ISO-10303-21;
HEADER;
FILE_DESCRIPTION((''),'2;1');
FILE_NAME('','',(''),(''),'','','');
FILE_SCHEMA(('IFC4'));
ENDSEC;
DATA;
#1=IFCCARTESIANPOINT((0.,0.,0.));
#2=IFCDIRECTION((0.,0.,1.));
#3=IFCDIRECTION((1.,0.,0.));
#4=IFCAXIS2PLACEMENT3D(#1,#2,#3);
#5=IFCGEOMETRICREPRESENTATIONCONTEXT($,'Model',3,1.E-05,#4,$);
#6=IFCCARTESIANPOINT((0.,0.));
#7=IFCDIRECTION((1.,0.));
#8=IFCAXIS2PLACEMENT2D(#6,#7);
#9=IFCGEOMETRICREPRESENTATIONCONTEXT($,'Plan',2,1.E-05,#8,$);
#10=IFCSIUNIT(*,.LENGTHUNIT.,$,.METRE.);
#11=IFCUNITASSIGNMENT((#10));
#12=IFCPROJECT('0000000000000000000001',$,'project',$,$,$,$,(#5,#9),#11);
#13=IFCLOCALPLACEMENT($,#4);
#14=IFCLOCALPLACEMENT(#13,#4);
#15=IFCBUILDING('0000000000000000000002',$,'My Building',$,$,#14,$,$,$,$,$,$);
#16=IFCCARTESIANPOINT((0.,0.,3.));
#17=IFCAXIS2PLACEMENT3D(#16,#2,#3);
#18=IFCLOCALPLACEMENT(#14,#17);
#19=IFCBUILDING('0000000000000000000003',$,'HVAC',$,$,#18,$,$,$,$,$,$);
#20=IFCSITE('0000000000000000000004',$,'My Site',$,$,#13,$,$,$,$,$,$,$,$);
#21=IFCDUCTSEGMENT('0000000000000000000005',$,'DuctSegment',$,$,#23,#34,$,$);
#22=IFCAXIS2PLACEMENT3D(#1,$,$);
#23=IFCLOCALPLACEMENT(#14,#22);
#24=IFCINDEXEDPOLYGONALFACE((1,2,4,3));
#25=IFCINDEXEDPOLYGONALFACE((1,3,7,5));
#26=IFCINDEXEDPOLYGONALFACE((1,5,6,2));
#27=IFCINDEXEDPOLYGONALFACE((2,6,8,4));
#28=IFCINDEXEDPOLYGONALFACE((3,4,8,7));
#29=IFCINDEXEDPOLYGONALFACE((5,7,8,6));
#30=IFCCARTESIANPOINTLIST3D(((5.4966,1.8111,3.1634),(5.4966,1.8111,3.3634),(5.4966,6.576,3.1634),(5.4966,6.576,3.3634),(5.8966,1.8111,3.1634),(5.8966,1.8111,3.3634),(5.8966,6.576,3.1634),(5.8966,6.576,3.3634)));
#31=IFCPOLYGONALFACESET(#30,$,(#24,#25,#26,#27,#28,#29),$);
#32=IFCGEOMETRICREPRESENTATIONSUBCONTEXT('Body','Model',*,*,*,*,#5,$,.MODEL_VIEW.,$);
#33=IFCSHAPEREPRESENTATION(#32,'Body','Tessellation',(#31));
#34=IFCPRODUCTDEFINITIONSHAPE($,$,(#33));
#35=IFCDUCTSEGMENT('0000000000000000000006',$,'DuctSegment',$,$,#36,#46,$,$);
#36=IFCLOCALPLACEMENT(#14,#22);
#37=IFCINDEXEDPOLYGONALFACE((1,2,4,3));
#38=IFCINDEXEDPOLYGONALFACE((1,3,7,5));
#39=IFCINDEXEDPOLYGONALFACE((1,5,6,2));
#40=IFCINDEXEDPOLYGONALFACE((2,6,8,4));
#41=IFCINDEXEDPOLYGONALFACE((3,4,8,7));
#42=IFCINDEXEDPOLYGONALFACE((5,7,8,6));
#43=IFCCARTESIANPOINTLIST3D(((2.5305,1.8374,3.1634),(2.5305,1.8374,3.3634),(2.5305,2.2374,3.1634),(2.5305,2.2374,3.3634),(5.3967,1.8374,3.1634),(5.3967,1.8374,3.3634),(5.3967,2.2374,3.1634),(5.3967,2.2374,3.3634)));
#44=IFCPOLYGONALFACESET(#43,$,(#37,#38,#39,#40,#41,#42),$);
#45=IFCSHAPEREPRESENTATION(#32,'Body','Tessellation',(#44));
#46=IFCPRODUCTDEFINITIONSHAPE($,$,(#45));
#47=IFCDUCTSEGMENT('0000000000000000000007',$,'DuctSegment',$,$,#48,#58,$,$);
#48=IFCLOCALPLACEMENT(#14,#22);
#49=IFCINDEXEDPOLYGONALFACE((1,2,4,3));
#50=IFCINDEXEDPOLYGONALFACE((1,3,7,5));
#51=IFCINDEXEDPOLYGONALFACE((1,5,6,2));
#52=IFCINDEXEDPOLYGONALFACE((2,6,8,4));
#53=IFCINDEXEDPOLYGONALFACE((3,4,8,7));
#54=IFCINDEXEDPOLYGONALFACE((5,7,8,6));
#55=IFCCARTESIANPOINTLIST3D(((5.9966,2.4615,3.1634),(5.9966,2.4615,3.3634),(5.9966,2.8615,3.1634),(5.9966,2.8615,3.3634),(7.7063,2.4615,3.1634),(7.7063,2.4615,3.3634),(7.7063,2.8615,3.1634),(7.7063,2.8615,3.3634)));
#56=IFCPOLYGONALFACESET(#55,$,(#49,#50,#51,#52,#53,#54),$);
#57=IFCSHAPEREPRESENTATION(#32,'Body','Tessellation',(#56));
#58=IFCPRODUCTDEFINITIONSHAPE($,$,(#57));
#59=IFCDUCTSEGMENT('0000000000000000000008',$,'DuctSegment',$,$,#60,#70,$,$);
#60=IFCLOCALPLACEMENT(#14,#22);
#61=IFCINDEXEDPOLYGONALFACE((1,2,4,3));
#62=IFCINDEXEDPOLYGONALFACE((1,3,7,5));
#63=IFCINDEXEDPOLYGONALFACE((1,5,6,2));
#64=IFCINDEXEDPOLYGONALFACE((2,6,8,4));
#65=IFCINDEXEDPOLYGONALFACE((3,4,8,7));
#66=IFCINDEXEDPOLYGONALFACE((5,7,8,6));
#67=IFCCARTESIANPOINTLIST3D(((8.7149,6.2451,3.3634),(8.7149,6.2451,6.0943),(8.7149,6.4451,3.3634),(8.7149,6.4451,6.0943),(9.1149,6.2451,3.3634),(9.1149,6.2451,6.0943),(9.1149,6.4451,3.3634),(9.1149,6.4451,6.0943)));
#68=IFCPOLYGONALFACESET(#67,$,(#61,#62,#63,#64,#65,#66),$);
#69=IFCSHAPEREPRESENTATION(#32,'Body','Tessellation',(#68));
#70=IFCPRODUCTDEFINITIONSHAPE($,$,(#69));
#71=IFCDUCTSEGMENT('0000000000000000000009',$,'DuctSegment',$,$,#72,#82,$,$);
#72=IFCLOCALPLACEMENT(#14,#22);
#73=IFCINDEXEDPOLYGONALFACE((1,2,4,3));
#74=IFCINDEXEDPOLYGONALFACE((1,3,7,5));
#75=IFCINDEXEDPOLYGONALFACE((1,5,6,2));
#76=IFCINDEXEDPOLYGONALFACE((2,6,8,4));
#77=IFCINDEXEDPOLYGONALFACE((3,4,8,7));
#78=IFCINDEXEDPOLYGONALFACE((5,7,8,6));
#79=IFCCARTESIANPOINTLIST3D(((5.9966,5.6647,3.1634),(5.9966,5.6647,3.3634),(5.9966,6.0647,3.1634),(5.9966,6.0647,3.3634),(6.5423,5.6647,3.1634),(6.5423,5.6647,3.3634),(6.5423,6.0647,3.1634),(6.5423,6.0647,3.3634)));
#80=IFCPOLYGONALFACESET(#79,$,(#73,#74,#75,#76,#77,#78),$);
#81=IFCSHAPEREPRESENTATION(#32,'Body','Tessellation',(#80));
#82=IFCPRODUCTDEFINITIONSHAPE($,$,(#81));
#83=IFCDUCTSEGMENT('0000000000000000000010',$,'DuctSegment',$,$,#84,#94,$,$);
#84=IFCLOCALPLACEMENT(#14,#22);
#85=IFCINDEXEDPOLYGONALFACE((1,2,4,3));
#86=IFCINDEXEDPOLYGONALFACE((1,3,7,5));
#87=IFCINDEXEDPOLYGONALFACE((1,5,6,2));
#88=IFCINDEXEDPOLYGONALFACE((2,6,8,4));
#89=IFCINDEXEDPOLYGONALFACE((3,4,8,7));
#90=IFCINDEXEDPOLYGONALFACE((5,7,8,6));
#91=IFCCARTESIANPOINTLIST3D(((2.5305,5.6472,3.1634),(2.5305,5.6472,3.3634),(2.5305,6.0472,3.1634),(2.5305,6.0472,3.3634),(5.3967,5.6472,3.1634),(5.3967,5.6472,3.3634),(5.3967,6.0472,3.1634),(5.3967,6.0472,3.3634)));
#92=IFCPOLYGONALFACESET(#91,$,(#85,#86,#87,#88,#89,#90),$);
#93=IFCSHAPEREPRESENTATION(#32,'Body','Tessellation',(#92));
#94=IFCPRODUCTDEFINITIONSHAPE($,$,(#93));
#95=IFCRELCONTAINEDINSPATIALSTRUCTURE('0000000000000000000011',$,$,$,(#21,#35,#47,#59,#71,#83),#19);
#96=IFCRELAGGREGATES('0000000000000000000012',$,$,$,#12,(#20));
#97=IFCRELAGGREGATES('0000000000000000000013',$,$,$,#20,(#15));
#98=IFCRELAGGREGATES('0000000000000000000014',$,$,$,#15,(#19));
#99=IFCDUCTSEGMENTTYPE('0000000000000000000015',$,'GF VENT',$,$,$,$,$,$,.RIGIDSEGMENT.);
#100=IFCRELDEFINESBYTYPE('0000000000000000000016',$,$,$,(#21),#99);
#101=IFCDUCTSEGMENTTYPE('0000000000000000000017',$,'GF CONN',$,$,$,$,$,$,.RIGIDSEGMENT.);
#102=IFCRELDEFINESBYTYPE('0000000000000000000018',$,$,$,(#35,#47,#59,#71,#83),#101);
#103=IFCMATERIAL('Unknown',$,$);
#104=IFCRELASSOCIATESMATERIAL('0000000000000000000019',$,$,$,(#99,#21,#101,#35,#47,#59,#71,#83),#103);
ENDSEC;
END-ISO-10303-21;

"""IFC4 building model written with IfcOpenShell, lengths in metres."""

from ifc_helpers import new_model, si_unit, frame, origin_with_axes, origin_2d_with_axis, place, context, subcontext, project, spatial, rectangle, extrude, material, material_profile, profile_set, profile_usage, type_object, element, save


model = new_model("IFC4")

# Units and contexts
model_context = context("Model", 3, precision=1e-05, world=origin_with_axes())
plan_context = context("Plan", 2, precision=1e-05, world=origin_2d_with_axis())
body_context = subcontext(model_context, "Body", "Model", "MODEL_VIEW")
ifc_project = project(units=[si_unit("LENGTHUNIT", "METRE")], contexts=[model_context, plan_context])

# Site, buildings
site_placement = place(None, origin_with_axes())
site = spatial("IfcSite", under=ifc_project, at=site_placement, Name="My Site")
building_1_placement = place(site_placement, origin_with_axes())
building_1 = spatial("IfcBuilding", under=site, at=building_1_placement, Name="My Building")
building_2_placement = place(building_1_placement, frame((0.0, 0.0, 3.0), z_axis=(0.0, 0.0, 1.0), x_axis=(1.0, 0.0, 0.0)))
building_2 = spatial("IfcBuilding", under=building_1, at=building_2_placement, Name="HVAC")

# Duct segments
ifc_material = material(Name="Unknown")
ifc_material_profile_1 = material_profile(ifc_material, rectangle(XDim=0.4, YDim=0.2))
ifc_profile_set_1 = profile_set([ifc_material_profile_1])
ifc_profile_usage_1 = profile_usage(ifc_profile_set_1, cardinal=3)
duct_segment_type_1 = type_object("IfcDuctSegmentType", Name="GF VENT", PredefinedType="RIGIDSEGMENT", material=ifc_profile_set_1)
duct_segment_1_placement = place(building_2_placement, frame((5.4966, 6.576, 0.1634), z_axis=(0.0, -1.0, 0.0), x_axis=(1.0, 0.0, 0.0)))
element("IfcDuctSegment", 1, at=duct_segment_1_placement, inside=building_2, type_object=duct_segment_type_1, material=ifc_profile_usage_1, Name="DuctSegment", context=body_context, shape_type="SweptSolid", body=[
    extrude(rectangle(XDim=0.4, YDim=0.2), frame((0.2, 0.1, 0.0), z_axis=(0.0, 0.0, 1.0), x_axis=(1.0, 0.0, 0.0)), (0.0, 0.0, 1.0), 4.7649),
])
ifc_material_profile_2 = material_profile(ifc_material, rectangle(XDim=0.4, YDim=0.2))
ifc_profile_set_2 = profile_set([ifc_material_profile_2])
ifc_profile_usage_2 = profile_usage(ifc_profile_set_2, cardinal=3)
duct_segment_type_2 = type_object("IfcDuctSegmentType", Name="GF CONN", PredefinedType="RIGIDSEGMENT", material=ifc_profile_set_2)
duct_segment_2_placement = place(building_2_placement, frame((5.3967, 2.2374, 0.1634), z_axis=(-1.0, 0.0, 0.0), x_axis=(0.0, -1.0, 0.0)))
element("IfcDuctSegment", 2, at=duct_segment_2_placement, inside=building_2, type_object=duct_segment_type_2, material=ifc_profile_usage_2, Name="DuctSegment", context=body_context, shape_type="SweptSolid", body=[
    extrude(rectangle(XDim=0.4, YDim=0.2), frame((0.2, 0.1, 0.0), z_axis=(0.0, 0.0, 1.0), x_axis=(1.0, 0.0, 0.0)), (0.0, 0.0, 1.0), 2.8662),
])
ifc_profile_usage_3 = profile_usage(ifc_profile_set_2, cardinal=3)
duct_segment_3_placement = place(building_2_placement, frame((7.7063, 2.8615, 0.1634), z_axis=(-1.0, 0.0, 0.0), x_axis=(0.0, -1.0, 0.0)))
element("IfcDuctSegment", 3, at=duct_segment_3_placement, inside=building_2, type_object=duct_segment_type_2, material=ifc_profile_usage_3, Name="DuctSegment", context=body_context, shape_type="SweptSolid", body=[
    extrude(rectangle(XDim=0.4, YDim=0.2), frame((0.2, 0.1, 0.0), z_axis=(0.0, 0.0, 1.0), x_axis=(1.0, 0.0, 0.0)), (0.0, 0.0, 1.0), 1.7097),
])
ifc_profile_usage_4 = profile_usage(ifc_profile_set_2, cardinal=3)
duct_segment_4_placement = place(building_2_placement, frame((9.1149, 6.4451, 0.3634), z_axis=(0.0, 0.0, 1.0), x_axis=(-1.0, 0.0, 0.0)))
element("IfcDuctSegment", 4, at=duct_segment_4_placement, inside=building_2, type_object=duct_segment_type_2, material=ifc_profile_usage_4, Name="DuctSegment", context=body_context, shape_type="SweptSolid", body=[
    extrude(rectangle(XDim=0.4, YDim=0.2), frame((0.2, 0.1, 0.0), z_axis=(0.0, 0.0, 1.0), x_axis=(1.0, 0.0, 0.0)), (0.0, 0.0, 1.0), 2.731),
])
ifc_profile_usage_5 = profile_usage(ifc_profile_set_2, cardinal=3)
duct_segment_5_placement = place(building_2_placement, frame((6.5423, 6.0647, 0.1634), z_axis=(-1.0, 0.0, 0.0), x_axis=(0.0, -1.0, 0.0)))
element("IfcDuctSegment", 5, at=duct_segment_5_placement, inside=building_2, type_object=duct_segment_type_2, material=ifc_profile_usage_5, Name="DuctSegment", context=body_context, shape_type="SweptSolid", body=[
    extrude(rectangle(XDim=0.4, YDim=0.2), frame((0.2, 0.1, 0.0), z_axis=(0.0, 0.0, 1.0), x_axis=(1.0, 0.0, 0.0)), (0.0, 0.0, 1.0), 0.5457),
])
ifc_profile_usage_6 = profile_usage(ifc_profile_set_2, cardinal=3)
duct_segment_6_placement = place(building_2_placement, frame((5.3967, 6.0472, 0.1634), z_axis=(-1.0, 0.0, 0.0), x_axis=(0.0, -1.0, 0.0)))
element("IfcDuctSegment", 6, at=duct_segment_6_placement, inside=building_2, type_object=duct_segment_type_2, material=ifc_profile_usage_6, Name="DuctSegment", context=body_context, shape_type="SweptSolid", body=[
    extrude(rectangle(XDim=0.4, YDim=0.2), frame((0.2, 0.1, 0.0), z_axis=(0.0, 0.0, 1.0), x_axis=(1.0, 0.0, 0.0)), (0.0, 0.0, 1.0), 2.8662),
])

save(model, "model.ifc")
